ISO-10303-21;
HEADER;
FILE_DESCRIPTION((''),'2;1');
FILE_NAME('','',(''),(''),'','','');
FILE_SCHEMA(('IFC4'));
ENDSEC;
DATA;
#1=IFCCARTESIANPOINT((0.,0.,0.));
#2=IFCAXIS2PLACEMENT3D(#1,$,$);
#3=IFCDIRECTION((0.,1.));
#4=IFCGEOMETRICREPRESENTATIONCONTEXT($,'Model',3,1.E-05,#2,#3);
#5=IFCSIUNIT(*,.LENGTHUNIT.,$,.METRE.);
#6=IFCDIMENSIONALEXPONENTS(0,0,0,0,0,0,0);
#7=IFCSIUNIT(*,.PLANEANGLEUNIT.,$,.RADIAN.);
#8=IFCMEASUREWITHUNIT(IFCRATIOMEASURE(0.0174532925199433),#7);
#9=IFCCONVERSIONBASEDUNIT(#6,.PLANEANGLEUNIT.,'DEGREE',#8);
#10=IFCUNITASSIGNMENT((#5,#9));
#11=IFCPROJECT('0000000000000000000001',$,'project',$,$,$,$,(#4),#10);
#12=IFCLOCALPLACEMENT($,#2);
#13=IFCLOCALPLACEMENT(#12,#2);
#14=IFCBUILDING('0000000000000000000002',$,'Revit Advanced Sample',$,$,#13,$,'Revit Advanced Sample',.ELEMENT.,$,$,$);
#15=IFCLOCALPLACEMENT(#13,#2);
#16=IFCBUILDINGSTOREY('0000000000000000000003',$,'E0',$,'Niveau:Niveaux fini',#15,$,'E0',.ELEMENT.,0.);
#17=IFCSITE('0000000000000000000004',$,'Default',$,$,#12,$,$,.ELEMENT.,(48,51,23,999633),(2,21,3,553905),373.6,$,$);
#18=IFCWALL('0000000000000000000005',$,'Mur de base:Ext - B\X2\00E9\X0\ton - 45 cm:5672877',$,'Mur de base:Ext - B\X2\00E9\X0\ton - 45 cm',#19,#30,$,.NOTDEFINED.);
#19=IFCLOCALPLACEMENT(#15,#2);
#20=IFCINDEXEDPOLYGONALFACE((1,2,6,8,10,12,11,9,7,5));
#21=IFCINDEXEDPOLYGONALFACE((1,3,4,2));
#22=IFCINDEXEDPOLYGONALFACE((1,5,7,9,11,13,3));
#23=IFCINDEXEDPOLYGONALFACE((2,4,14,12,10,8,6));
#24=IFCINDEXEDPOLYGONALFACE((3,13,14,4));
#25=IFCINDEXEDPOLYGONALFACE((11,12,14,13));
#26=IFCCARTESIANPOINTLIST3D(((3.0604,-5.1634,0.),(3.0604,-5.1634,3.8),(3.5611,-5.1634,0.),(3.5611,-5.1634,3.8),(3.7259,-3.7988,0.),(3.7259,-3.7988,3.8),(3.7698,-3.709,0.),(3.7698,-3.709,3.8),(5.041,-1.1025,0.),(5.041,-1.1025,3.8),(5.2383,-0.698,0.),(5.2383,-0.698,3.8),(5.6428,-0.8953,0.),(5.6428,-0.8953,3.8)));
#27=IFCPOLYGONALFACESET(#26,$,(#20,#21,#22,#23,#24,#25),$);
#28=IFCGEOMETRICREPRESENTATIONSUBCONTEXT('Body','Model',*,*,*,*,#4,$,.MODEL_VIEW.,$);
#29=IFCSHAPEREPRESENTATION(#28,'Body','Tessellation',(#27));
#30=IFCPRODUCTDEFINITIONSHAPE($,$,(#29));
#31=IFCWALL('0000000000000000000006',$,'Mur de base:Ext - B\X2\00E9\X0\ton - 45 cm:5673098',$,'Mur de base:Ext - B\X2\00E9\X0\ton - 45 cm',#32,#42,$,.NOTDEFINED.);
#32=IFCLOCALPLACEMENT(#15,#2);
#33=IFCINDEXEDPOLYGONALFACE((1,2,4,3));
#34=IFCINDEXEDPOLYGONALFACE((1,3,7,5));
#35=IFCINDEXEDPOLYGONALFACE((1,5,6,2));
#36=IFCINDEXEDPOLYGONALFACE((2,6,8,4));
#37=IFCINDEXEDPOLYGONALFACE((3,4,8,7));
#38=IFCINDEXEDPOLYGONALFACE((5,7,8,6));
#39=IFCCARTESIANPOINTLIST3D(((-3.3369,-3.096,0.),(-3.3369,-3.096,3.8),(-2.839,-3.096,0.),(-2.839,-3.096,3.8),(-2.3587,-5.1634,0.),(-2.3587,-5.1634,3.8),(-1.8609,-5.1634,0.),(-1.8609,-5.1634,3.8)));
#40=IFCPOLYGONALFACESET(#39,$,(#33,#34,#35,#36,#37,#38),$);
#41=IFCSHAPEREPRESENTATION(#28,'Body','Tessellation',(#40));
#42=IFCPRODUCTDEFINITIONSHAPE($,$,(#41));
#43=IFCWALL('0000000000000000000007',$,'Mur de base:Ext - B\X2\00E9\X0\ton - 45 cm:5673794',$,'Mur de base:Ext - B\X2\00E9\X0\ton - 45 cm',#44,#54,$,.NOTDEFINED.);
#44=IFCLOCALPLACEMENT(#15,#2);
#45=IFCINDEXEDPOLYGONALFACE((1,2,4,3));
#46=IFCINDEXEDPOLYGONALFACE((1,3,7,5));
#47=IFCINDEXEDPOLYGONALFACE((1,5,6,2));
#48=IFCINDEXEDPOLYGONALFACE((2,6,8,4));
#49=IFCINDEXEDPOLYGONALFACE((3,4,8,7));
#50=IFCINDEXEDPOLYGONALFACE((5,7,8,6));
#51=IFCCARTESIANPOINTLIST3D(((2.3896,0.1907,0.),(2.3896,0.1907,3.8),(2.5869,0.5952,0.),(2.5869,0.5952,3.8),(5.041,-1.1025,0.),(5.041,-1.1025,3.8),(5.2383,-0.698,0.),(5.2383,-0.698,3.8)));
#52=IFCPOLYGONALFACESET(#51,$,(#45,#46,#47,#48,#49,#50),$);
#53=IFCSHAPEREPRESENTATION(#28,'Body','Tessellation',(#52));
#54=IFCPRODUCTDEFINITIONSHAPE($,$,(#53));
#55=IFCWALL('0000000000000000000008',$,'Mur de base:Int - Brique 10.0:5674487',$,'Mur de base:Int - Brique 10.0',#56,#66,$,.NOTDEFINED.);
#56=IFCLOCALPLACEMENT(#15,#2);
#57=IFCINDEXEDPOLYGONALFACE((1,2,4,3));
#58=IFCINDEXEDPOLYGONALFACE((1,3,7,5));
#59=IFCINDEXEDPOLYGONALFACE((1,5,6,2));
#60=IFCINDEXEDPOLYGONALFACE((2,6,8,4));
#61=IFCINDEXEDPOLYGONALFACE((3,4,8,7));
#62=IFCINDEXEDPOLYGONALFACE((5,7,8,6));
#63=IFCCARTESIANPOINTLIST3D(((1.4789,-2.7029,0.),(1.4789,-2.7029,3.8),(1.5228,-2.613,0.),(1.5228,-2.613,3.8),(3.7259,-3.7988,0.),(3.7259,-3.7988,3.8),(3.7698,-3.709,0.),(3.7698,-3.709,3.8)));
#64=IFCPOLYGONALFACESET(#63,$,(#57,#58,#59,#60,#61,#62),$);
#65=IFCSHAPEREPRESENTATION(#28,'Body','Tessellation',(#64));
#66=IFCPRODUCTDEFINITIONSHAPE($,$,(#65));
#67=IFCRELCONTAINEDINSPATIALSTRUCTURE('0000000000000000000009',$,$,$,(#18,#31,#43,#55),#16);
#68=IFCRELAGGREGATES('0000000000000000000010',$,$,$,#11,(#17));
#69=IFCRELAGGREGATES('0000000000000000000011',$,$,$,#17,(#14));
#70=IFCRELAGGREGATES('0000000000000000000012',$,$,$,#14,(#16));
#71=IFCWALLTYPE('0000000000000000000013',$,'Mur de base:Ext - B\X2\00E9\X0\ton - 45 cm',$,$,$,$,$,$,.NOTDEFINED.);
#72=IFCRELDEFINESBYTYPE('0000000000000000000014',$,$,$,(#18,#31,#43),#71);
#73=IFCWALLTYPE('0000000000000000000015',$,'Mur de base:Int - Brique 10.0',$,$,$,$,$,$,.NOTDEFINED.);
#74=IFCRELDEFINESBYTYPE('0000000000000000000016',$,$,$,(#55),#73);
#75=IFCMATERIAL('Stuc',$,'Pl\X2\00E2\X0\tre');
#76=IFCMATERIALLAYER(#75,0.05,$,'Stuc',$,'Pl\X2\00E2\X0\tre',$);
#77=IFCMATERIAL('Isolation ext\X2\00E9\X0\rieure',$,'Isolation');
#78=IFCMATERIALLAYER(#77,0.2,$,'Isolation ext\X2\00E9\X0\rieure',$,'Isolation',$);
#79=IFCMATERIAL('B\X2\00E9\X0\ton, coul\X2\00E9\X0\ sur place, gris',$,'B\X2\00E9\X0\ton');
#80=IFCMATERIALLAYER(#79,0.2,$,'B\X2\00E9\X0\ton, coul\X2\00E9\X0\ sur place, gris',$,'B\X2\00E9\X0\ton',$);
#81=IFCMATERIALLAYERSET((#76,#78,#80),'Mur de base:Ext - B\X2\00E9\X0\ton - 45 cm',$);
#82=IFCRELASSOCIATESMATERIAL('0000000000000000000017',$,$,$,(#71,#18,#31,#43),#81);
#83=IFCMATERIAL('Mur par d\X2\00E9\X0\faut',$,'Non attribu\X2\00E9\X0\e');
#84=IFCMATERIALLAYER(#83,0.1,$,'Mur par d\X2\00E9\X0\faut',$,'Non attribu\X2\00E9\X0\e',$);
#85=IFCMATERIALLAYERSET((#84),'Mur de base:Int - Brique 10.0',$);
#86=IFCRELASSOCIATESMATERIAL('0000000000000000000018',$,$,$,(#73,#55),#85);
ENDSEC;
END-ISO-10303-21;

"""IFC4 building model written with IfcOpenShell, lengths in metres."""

from ifc_helpers import new_model, entity, si_unit, converted_unit, direction, frame, origin, place, context, subcontext, project, spatial, indexed_curve, outline, extrude, material, layer, layer_set, type_object, element, save


model = new_model("IFC4")

# Units and contexts
model_context = context("Model", 3, precision=1e-05, world=origin(), true_north=direction((0.0, 1.0)))
body_context = subcontext(model_context, "Body", "Model", "MODEL_VIEW")
ifc_project = project(units=[si_unit("LENGTHUNIT", "METRE"), converted_unit("PLANEANGLEUNIT", "DEGREE", entity("IfcRatioMeasure", 0.0174532925199433), si_unit("PLANEANGLEUNIT", "RADIAN"), dimensions=[0, 0, 0, 0, 0, 0, 0])], contexts=[model_context])

# Site, building, storey
site_placement = place(None, origin())
site = spatial("IfcSite", under=ifc_project, at=site_placement, Name="Default", CompositionType="ELEMENT", RefLatitude=(48, 51, 23, 999633), RefLongitude=(2, 21, 3, 553905), RefElevation=373.6)
building_placement = place(site_placement, origin())
building = spatial("IfcBuilding", under=site, at=building_placement, Name="Revit Advanced Sample", LongName="Revit Advanced Sample", CompositionType="ELEMENT")
storey_placement = place(building_placement, origin())
storey = spatial("IfcBuildingStorey", under=building, at=storey_placement, Name="E0", ObjectType="Niveau:Niveaux fini", LongName="E0", CompositionType="ELEMENT", Elevation=0.0)

# Walls
ifc_material_1 = material(Name="Stuc", Category="Plâtre")
ifc_layer_1 = layer(ifc_material_1, 0.05, Name="Stuc", Category="Plâtre")
ifc_material_2 = material(Name="Isolation extérieure", Category="Isolation")
ifc_layer_2 = layer(ifc_material_2, 0.2, Name="Isolation extérieure", Category="Isolation")
ifc_material_3 = material(Name="Béton, coulé sur place, gris", Category="Béton")
ifc_layer_3 = layer(ifc_material_3, 0.2, Name="Béton, coulé sur place, gris", Category="Béton")
ifc_layer_set_1 = layer_set([ifc_layer_1, ifc_layer_2, ifc_layer_3], Name="Mur de base:Ext - Béton - 45 cm")
wall_type_1 = type_object("IfcWallType", Name="Mur de base:Ext - Béton - 45 cm", PredefinedType="NOTDEFINED", material=ifc_layer_set_1)
wall_1_placement = place(storey_placement, frame((3.2626, -5.262, 0.0), z_axis=(0.0, 0.0, 1.0), x_axis=(0.438371, 0.898794, 0.0)))
element("IfcWall", 1, at=wall_1_placement, inside=storey, type_object=wall_type_1, material=ifc_layer_set_1, Name="Mur de base:Ext - Béton - 45 cm:5672877", ObjectType="Mur de base:Ext - Béton - 45 cm", PredefinedType="NOTDEFINED", context=body_context, shape_type="SweptSolid", body=[
    extrude(outline(indexed_curve([(4.9682, -0.225), (4.9682, 0.225), (4.5182, 0.225), (1.6182, 0.225), (1.5182, 0.225), (0.0, 0.225), (0.2195, -0.225), (4.9682, -0.225)], self_intersect=False)), origin(), (0.0, 0.0, 1.0), 3.8),
])
wall_2_placement = place(storey_placement, frame((-3.1335, -2.9998, 0.0), z_axis=(0.0, 0.0, 1.0), x_axis=(0.427693, -0.903924, 0.0)))
element("IfcWall", 2, at=wall_2_placement, inside=storey, type_object=wall_type_1, material=ifc_layer_set_1, Name="Mur de base:Ext - Béton - 45 cm:5673098", ObjectType="Mur de base:Ext - Béton - 45 cm", PredefinedType="NOTDEFINED", context=body_context, shape_type="SweptSolid", body=[
    extrude(outline(indexed_curve([(2.2871, -0.225), (2.5, 0.225), (0.2129, 0.225), (0.0, -0.225), (2.2871, -0.225)], self_intersect=False)), origin(), (0.0, 0.0, 1.0), 3.8),
])
wall_3_placement = place(storey_placement, frame((5.1397, -0.9002, 0.0), z_axis=(0.0, 0.0, 1.0), x_axis=(-0.898794, 0.438371, 0.0)))
element("IfcWall", 3, at=wall_3_placement, inside=storey, type_object=wall_type_1, material=ifc_layer_set_1, Name="Mur de base:Ext - Béton - 45 cm:5673794", ObjectType="Mur de base:Ext - Béton - 45 cm", PredefinedType="NOTDEFINED", context=body_context, shape_type="SweptSolid", body=[
    extrude(outline(indexed_curve([(2.95, 0.225), (0.0, 0.225), (0.0, -0.225), (2.95, -0.225), (2.95, 0.225)], self_intersect=False)), origin(), (0.0, 0.0, 1.0), 3.8),
])
ifc_material_4 = material(Name="Mur par défaut", Category="Non attribuée")
ifc_layer_4 = layer(ifc_material_4, 0.1, Name="Mur par défaut", Category="Non attribuée")
ifc_layer_set_2 = layer_set([ifc_layer_4], Name="Mur de base:Int - Brique 10.0")
wall_type_2 = type_object("IfcWallType", Name="Mur de base:Int - Brique 10.0", PredefinedType="NOTDEFINED", material=ifc_layer_set_2)
wall_4_placement = place(storey_placement, frame((1.5008, -2.658, 0.0), z_axis=(0.0, 0.0, 1.0), x_axis=(0.898794, -0.438371, 0.0)))
element("IfcWall", 4, at=wall_4_placement, inside=storey, type_object=wall_type_2, material=ifc_layer_set_2, Name="Mur de base:Int - Brique 10.0:5674487", ObjectType="Mur de base:Int - Brique 10.0", PredefinedType="NOTDEFINED", context=body_context, shape_type="SweptSolid", body=[
    extrude(outline(indexed_curve([(2.5, 0.05), (0.0, 0.05), (0.0, -0.05), (2.5, -0.05), (2.5, 0.05)], self_intersect=False)), origin(), (0.0, 0.0, 1.0), 3.8),
])

save(model, "model.ifc")
